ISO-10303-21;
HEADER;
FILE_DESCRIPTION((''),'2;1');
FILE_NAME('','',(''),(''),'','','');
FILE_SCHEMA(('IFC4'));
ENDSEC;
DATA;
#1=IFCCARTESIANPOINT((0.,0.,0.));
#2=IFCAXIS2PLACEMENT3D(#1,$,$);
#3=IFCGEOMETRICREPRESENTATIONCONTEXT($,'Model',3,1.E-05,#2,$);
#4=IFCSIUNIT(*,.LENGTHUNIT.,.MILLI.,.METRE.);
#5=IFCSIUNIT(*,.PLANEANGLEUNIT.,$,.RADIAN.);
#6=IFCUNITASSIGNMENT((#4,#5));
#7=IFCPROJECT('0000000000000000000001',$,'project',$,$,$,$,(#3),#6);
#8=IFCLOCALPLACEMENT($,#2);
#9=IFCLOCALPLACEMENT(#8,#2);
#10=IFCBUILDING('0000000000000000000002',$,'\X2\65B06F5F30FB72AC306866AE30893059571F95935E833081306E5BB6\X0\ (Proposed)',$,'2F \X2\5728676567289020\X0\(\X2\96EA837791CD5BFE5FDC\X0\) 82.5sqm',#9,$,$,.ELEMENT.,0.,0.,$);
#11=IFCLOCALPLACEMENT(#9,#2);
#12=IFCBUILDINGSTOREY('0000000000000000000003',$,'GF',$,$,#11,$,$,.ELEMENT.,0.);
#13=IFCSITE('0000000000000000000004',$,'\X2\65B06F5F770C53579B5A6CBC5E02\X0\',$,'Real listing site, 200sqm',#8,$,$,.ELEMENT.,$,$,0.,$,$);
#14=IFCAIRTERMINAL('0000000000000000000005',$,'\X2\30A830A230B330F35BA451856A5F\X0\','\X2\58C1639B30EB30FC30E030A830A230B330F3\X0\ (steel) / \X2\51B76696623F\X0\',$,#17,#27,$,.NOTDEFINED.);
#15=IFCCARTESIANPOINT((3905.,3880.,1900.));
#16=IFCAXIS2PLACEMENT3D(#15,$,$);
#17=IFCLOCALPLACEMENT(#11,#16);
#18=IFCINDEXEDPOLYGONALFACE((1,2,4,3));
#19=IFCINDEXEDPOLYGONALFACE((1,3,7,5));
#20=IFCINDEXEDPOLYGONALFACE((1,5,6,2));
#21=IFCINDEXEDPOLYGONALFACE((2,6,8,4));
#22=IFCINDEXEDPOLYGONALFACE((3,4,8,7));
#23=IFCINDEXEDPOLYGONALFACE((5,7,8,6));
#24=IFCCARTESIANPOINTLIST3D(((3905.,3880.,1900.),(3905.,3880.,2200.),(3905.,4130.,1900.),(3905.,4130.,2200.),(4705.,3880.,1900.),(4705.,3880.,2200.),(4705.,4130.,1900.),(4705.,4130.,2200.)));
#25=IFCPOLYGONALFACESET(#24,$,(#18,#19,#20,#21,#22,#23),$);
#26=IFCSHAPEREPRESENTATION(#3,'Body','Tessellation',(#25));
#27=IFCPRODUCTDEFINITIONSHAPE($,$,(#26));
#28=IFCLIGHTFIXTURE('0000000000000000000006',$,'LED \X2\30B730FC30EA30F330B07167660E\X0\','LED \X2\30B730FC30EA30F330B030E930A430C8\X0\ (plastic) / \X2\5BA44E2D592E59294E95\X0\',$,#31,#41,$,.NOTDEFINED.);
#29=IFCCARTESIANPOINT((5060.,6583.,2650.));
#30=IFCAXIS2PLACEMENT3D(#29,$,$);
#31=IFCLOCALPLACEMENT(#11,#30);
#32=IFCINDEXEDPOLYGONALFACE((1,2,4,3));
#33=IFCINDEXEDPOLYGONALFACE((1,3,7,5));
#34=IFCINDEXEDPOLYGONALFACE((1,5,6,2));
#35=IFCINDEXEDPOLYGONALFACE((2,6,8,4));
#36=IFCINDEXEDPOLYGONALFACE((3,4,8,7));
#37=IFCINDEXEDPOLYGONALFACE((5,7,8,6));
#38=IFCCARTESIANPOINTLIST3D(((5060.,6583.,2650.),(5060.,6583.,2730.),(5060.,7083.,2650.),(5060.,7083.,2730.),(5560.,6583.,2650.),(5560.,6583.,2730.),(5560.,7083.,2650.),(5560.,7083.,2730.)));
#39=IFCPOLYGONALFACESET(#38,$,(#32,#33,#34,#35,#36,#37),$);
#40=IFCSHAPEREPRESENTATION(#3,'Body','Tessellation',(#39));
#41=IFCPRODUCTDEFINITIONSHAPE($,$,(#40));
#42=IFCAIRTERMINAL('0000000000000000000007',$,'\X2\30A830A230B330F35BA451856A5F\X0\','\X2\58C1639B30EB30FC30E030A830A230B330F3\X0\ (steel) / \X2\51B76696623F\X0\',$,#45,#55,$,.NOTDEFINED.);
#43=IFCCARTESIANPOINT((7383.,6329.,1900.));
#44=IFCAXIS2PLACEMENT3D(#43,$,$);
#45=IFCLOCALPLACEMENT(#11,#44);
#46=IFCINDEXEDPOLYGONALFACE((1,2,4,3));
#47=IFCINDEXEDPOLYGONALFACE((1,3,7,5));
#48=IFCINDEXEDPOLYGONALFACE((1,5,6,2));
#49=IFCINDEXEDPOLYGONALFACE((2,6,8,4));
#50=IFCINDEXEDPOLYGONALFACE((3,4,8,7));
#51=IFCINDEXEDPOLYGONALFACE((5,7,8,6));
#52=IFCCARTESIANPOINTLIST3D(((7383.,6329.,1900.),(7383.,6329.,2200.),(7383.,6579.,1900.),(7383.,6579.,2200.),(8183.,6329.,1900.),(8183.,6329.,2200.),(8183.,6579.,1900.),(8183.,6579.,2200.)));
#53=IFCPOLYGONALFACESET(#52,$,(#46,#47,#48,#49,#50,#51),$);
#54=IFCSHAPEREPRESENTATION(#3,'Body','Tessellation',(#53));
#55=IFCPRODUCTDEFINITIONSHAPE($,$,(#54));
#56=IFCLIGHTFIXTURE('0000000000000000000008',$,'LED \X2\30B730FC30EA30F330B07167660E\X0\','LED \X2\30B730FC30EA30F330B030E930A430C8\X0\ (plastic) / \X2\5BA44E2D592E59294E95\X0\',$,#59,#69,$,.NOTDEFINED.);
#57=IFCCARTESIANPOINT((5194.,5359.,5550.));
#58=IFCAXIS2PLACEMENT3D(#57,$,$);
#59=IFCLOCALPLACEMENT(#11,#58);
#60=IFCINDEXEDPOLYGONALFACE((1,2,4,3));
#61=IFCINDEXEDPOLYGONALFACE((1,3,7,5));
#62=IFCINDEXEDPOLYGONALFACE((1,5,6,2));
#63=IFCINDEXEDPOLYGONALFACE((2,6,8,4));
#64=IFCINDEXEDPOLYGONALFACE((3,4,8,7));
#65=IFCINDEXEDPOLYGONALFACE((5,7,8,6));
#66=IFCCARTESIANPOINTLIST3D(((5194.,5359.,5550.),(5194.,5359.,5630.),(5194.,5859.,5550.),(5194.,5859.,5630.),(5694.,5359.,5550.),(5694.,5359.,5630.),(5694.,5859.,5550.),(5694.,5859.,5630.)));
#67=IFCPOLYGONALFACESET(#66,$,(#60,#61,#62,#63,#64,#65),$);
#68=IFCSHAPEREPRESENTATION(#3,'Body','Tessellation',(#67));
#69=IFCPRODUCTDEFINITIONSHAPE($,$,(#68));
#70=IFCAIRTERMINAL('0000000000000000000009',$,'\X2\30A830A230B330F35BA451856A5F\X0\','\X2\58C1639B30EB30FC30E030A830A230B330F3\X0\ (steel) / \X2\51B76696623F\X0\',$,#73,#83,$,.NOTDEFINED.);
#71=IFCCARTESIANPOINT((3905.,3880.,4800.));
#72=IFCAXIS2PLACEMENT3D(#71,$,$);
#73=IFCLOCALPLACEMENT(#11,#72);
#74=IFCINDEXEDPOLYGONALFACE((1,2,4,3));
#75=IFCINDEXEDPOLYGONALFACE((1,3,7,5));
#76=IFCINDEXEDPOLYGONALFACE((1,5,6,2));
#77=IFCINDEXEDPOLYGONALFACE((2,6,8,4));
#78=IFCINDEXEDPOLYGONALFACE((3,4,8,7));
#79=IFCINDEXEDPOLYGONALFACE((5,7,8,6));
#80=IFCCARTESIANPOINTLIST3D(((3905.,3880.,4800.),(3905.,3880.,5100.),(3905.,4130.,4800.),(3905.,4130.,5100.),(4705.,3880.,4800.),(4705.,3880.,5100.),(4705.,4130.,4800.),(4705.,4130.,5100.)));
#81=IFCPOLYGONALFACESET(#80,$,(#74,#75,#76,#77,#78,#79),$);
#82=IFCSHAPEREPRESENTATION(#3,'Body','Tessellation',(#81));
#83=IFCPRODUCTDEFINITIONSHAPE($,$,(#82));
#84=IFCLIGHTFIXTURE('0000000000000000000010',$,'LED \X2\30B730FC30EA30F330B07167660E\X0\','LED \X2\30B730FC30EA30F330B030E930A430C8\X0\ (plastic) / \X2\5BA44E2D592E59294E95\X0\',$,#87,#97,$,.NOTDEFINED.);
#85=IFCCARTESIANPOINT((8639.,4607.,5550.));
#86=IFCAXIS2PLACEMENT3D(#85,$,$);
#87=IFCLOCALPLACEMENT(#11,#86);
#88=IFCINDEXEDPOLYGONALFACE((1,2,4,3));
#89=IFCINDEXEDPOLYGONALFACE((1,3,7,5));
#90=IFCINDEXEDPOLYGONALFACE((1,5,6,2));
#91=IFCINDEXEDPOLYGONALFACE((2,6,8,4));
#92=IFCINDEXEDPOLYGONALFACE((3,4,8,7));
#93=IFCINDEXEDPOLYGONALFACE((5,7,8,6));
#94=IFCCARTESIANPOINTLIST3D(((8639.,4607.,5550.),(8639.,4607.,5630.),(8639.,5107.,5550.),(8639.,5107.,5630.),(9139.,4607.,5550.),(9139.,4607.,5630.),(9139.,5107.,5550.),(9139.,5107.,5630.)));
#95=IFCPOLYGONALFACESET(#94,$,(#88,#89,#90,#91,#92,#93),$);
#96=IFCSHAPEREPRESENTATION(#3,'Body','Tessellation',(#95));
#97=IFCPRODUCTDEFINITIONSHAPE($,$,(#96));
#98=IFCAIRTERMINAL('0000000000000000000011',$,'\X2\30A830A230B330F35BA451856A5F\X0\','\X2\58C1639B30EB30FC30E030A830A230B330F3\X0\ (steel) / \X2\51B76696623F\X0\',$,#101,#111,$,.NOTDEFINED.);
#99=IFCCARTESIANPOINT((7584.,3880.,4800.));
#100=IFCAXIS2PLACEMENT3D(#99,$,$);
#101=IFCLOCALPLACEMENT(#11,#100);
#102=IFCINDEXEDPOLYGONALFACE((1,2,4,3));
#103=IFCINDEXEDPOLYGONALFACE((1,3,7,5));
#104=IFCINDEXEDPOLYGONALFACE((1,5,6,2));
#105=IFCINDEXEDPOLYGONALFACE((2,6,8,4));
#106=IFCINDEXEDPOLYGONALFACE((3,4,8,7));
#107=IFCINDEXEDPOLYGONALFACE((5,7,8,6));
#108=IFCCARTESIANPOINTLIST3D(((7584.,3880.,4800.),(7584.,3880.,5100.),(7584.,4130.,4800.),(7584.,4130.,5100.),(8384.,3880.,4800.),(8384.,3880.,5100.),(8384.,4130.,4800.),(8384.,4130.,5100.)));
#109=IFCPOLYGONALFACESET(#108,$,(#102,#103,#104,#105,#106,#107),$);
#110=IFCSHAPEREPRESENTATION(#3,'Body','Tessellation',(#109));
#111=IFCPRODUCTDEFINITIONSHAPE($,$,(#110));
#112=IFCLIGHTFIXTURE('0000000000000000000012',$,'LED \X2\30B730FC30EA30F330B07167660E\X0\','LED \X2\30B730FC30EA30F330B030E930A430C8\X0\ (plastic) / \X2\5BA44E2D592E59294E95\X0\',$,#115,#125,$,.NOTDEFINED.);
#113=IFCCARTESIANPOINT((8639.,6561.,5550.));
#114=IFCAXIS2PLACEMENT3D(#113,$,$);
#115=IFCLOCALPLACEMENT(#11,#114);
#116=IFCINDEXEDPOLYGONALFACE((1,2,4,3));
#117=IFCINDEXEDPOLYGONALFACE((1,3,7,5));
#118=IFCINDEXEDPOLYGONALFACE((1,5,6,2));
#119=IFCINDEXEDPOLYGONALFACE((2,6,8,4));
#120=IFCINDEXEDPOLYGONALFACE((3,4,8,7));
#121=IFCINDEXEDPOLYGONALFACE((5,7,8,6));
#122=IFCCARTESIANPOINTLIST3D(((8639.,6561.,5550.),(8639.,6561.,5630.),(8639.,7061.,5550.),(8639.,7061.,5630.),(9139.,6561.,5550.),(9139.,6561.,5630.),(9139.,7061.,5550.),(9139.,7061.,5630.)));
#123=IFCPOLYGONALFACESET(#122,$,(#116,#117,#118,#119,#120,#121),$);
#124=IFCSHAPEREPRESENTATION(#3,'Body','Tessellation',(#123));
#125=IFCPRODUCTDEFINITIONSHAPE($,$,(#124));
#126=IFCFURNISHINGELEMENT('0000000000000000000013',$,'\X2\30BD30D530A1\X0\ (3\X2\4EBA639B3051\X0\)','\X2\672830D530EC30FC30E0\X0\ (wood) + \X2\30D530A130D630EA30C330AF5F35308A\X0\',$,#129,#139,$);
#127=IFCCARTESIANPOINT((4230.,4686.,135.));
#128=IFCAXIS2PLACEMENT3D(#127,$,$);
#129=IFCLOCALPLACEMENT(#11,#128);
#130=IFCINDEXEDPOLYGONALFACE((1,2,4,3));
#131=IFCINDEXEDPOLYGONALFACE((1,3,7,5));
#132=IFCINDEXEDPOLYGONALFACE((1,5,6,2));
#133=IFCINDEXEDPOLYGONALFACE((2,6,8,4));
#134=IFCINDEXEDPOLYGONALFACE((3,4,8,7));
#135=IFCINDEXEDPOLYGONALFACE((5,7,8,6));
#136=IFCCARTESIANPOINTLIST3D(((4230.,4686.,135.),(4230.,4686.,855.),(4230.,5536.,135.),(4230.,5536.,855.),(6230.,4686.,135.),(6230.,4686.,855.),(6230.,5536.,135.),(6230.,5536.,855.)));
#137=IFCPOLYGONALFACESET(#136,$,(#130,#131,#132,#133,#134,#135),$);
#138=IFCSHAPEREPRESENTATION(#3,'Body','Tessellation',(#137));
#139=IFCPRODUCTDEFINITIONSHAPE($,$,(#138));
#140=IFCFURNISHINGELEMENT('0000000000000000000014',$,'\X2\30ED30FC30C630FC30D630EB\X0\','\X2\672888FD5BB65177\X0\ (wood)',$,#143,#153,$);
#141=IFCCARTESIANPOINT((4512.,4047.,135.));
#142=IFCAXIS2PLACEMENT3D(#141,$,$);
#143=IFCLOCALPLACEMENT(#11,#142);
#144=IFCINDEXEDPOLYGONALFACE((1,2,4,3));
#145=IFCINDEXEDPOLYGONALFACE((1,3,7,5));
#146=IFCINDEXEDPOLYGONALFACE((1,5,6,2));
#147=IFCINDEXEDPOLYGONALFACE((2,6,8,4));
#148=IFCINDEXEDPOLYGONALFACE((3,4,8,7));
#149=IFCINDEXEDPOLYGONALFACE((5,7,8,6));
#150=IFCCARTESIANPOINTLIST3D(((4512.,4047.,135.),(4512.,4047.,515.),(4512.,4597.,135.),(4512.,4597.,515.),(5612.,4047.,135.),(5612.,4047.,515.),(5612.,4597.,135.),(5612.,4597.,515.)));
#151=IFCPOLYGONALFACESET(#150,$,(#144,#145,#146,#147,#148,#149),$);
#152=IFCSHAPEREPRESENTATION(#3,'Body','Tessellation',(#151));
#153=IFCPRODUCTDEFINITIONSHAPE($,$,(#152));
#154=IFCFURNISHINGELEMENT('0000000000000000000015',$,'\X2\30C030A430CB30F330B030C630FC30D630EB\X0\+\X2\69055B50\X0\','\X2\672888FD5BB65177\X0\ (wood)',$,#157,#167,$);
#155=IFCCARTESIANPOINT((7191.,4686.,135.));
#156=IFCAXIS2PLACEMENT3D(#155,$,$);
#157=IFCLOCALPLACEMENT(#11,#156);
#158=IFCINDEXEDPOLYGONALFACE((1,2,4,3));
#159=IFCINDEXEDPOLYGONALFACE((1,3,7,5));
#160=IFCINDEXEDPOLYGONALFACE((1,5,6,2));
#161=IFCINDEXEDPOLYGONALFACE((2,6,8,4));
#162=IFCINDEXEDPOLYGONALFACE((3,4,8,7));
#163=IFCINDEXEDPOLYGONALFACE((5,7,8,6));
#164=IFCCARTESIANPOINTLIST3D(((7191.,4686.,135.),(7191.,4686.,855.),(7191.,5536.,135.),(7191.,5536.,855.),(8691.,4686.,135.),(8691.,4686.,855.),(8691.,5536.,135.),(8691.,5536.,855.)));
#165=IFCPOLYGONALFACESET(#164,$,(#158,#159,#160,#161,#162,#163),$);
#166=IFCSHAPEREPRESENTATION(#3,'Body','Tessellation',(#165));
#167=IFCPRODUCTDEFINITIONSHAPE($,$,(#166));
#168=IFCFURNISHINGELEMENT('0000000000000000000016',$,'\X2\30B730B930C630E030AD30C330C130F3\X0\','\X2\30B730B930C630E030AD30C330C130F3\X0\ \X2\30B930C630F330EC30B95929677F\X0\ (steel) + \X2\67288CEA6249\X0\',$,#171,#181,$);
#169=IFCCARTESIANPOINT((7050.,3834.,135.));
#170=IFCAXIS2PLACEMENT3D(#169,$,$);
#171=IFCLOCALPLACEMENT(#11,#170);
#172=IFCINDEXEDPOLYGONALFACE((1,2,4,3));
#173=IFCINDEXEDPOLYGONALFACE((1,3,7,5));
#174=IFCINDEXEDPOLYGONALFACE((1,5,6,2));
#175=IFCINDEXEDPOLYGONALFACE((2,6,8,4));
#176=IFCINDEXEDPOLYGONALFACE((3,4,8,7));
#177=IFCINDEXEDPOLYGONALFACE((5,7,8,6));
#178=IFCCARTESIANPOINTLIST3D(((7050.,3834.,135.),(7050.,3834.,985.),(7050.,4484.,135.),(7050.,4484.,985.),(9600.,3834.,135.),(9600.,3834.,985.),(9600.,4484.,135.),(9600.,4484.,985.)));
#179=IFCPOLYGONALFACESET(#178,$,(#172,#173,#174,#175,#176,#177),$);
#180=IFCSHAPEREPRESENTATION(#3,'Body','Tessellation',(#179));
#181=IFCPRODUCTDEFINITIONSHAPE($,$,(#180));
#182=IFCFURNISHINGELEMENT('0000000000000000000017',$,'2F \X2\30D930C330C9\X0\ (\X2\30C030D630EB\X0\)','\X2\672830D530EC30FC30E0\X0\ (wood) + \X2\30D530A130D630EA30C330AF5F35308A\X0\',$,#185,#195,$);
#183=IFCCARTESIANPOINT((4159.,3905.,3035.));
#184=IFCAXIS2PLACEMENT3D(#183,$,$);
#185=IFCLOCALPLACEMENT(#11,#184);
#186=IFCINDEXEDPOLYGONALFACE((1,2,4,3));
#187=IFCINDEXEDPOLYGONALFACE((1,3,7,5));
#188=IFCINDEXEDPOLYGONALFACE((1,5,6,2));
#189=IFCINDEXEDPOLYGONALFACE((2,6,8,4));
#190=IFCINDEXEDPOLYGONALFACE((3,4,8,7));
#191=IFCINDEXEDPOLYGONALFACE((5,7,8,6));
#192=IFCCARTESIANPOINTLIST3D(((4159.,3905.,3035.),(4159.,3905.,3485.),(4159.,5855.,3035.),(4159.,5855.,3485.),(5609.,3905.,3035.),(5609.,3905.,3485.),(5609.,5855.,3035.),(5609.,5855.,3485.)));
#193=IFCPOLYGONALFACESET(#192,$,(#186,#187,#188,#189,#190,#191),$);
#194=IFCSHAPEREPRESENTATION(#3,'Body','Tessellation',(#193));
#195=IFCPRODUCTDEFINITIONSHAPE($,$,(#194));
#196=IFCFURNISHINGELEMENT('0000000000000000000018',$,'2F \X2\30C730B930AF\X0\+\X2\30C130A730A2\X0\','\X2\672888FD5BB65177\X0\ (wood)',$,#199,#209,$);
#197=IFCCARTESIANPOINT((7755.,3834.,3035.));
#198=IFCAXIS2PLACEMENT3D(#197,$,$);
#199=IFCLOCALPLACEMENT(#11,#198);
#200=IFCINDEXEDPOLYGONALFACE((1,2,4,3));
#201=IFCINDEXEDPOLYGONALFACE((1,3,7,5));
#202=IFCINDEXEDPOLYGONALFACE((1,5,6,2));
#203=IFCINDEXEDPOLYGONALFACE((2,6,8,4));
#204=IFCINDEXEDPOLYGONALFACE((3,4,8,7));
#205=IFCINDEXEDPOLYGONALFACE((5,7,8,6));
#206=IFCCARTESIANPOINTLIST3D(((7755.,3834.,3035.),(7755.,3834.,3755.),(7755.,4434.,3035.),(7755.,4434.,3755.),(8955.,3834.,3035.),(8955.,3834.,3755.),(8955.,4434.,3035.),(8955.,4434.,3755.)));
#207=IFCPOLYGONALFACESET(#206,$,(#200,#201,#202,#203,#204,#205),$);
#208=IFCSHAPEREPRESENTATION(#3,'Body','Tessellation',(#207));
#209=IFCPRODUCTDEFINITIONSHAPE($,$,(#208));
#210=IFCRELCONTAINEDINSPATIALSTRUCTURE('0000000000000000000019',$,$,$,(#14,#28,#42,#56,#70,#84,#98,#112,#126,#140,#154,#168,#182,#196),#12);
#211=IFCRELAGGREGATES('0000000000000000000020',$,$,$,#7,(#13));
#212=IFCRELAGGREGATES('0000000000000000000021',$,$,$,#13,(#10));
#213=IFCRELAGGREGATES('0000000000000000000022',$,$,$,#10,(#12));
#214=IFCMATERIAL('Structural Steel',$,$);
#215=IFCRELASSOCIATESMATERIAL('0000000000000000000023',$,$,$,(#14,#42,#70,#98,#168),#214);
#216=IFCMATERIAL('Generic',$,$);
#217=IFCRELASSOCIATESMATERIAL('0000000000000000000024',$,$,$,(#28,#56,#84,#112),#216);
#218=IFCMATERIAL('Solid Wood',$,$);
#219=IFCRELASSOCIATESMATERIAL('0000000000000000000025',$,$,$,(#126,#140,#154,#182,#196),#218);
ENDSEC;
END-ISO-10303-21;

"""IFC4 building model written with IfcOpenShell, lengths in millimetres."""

from ifc_helpers import new_model, si_unit, frame, frame_2d, origin, place, context, project, spatial, rectangle, extrude, material, element, save


model = new_model("IFC4")

# Units and contexts
model_context = context("Model", 3, precision=1e-05, world=origin())
ifc_project = project(units=[si_unit("LENGTHUNIT", "METRE", prefix="MILLI"), si_unit("PLANEANGLEUNIT", "RADIAN")], contexts=[model_context])

# Site, building, storey
site_placement = place(None, origin())
site = spatial("IfcSite", under=ifc_project, at=site_placement, Name="新潟県南魚沼市", ObjectType="Real listing site, 200sqm", CompositionType="ELEMENT", RefElevation=0.0)
building_placement = place(site_placement, origin())
building = spatial("IfcBuilding", under=site, at=building_placement, Name="新潟・犬と暮らす土間広めの家 (Proposed)", ObjectType="2F 在来木造(雪荷重対応) 82.5sqm", CompositionType="ELEMENT", ElevationOfRefHeight=0.0, ElevationOfTerrain=0.0)
storey_placement = place(building_placement, origin())
storey = spatial("IfcBuildingStorey", under=building, at=storey_placement, Name="GF", CompositionType="ELEMENT", Elevation=0.0)

# Shared definitions
ifc_material_1 = material(Name="Solid Wood")

# Shared definitions
ifc_material_2 = material(Name="Structural Steel")

# Shared definitions
ifc_material_3 = material(Name="Generic")

# Air terminal
air_terminal_1_placement = place(storey_placement, frame((3905.0, 3880.0, 1900.0)))
element("IfcAirTerminal", 1, at=air_terminal_1_placement, inside=storey, material=ifc_material_2, Name="エアコン室内機", Description="壁掛ルームエアコン (steel) / 冷暖房", PredefinedType="NOTDEFINED", context=model_context, shape_type="SweptSolid", body=[
    extrude(rectangle(XDim=800.0, YDim=250.0, at=frame_2d((400.0, 125.0))), frame((3905.0, 3880.0, 1900.0)), (0.0, 0.0, 1.0), 300.0),
])

# Light fixture
light_fixture_1_placement = place(storey_placement, frame((5060.0, 6583.0, 2650.0)))
element("IfcLightFixture", 2, at=light_fixture_1_placement, inside=storey, material=ifc_material_3, Name="LED シーリング照明", Description="LED シーリングライト (plastic) / 室中央天井", PredefinedType="NOTDEFINED", context=model_context, shape_type="SweptSolid", body=[
    extrude(rectangle(XDim=500.0, YDim=500.0, at=frame_2d((250.0, 250.0))), frame((5060.0, 6583.0, 2650.0)), (0.0, 0.0, 1.0), 80.0),
])

# Air terminal
air_terminal_2_placement = place(storey_placement, frame((7383.0, 6329.0, 1900.0)))
element("IfcAirTerminal", 3, at=air_terminal_2_placement, inside=storey, material=ifc_material_2, Name="エアコン室内機", Description="壁掛ルームエアコン (steel) / 冷暖房", PredefinedType="NOTDEFINED", context=model_context, shape_type="SweptSolid", body=[
    extrude(rectangle(XDim=800.0, YDim=250.0, at=frame_2d((400.0, 125.0))), frame((7383.0, 6329.0, 1900.0)), (0.0, 0.0, 1.0), 300.0),
])

# Light fixture
light_fixture_2_placement = place(storey_placement, frame((5194.0, 5359.0, 5550.0)))
element("IfcLightFixture", 4, at=light_fixture_2_placement, inside=storey, material=ifc_material_3, Name="LED シーリング照明", Description="LED シーリングライト (plastic) / 室中央天井", PredefinedType="NOTDEFINED", context=model_context, shape_type="SweptSolid", body=[
    extrude(rectangle(XDim=500.0, YDim=500.0, at=frame_2d((250.0, 250.0))), frame((5194.0, 5359.0, 5550.0)), (0.0, 0.0, 1.0), 80.0),
])

# Air terminal
air_terminal_3_placement = place(storey_placement, frame((3905.0, 3880.0, 4800.0)))
element("IfcAirTerminal", 5, at=air_terminal_3_placement, inside=storey, material=ifc_material_2, Name="エアコン室内機", Description="壁掛ルームエアコン (steel) / 冷暖房", PredefinedType="NOTDEFINED", context=model_context, shape_type="SweptSolid", body=[
    extrude(rectangle(XDim=800.0, YDim=250.0, at=frame_2d((400.0, 125.0))), frame((3905.0, 3880.0, 4800.0)), (0.0, 0.0, 1.0), 300.0),
])

# Light fixture
light_fixture_3_placement = place(storey_placement, frame((8639.0, 4607.0, 5550.0)))
element("IfcLightFixture", 6, at=light_fixture_3_placement, inside=storey, material=ifc_material_3, Name="LED シーリング照明", Description="LED シーリングライト (plastic) / 室中央天井", PredefinedType="NOTDEFINED", context=model_context, shape_type="SweptSolid", body=[
    extrude(rectangle(XDim=500.0, YDim=500.0, at=frame_2d((250.0, 250.0))), frame((8639.0, 4607.0, 5550.0)), (0.0, 0.0, 1.0), 80.0),
])

# Air terminal
air_terminal_4_placement = place(storey_placement, frame((7584.0, 3880.0, 4800.0)))
element("IfcAirTerminal", 7, at=air_terminal_4_placement, inside=storey, material=ifc_material_2, Name="エアコン室内機", Description="壁掛ルームエアコン (steel) / 冷暖房", PredefinedType="NOTDEFINED", context=model_context, shape_type="SweptSolid", body=[
    extrude(rectangle(XDim=800.0, YDim=250.0, at=frame_2d((400.0, 125.0))), frame((7584.0, 3880.0, 4800.0)), (0.0, 0.0, 1.0), 300.0),
])

# Light fixture
light_fixture_4_placement = place(storey_placement, frame((8639.0, 6561.0, 5550.0)))
element("IfcLightFixture", 8, at=light_fixture_4_placement, inside=storey, material=ifc_material_3, Name="LED シーリング照明", Description="LED シーリングライト (plastic) / 室中央天井", PredefinedType="NOTDEFINED", context=model_context, shape_type="SweptSolid", body=[
    extrude(rectangle(XDim=500.0, YDim=500.0, at=frame_2d((250.0, 250.0))), frame((8639.0, 6561.0, 5550.0)), (0.0, 0.0, 1.0), 80.0),
])

# Furnishing elements
furnishing_1_placement = place(storey_placement, frame((4230.0, 4686.0, 135.0)))
element("IfcFurnishingElement", 9, at=furnishing_1_placement, inside=storey, material=ifc_material_1, Name="ソファ (3人掛け)", Description="木フレーム (wood) + ファブリック張り", context=model_context, shape_type="SweptSolid", body=[
    extrude(rectangle(XDim=2000.0, YDim=850.0, at=frame_2d((1000.0, 425.0))), frame((4230.0, 4686.0, 135.0)), (0.0, 0.0, 1.0), 720.0),
])
furnishing_2_placement = place(storey_placement, frame((4512.0, 4047.0, 135.0)))
element("IfcFurnishingElement", 10, at=furnishing_2_placement, inside=storey, material=ifc_material_1, Name="ローテーブル", Description="木製家具 (wood)", context=model_context, shape_type="SweptSolid", body=[
    extrude(rectangle(XDim=1100.0, YDim=550.0, at=frame_2d((550.0, 275.0))), frame((4512.0, 4047.0, 135.0)), (0.0, 0.0, 1.0), 380.0),
])
furnishing_3_placement = place(storey_placement, frame((7191.0, 4686.0, 135.0)))
element("IfcFurnishingElement", 11, at=furnishing_3_placement, inside=storey, material=ifc_material_1, Name="ダイニングテーブル+椅子", Description="木製家具 (wood)", context=model_context, shape_type="SweptSolid", body=[
    extrude(rectangle(XDim=1500.0, YDim=850.0, at=frame_2d((750.0, 425.0))), frame((7191.0, 4686.0, 135.0)), (0.0, 0.0, 1.0), 720.0),
])
furnishing_4_placement = place(storey_placement, frame((7050.0, 3834.0, 135.0)))
element("IfcFurnishingElement", 12, at=furnishing_4_placement, inside=storey, material=ifc_material_2, Name="システムキッチン", Description="システムキッチン ステンレス天板 (steel) + 木質扉", context=model_context, shape_type="SweptSolid", body=[
    extrude(rectangle(XDim=2550.0, YDim=650.0, at=frame_2d((1275.0, 325.0))), frame((7050.0, 3834.0, 135.0)), (0.0, 0.0, 1.0), 850.0),
])
furnishing_5_placement = place(storey_placement, frame((4159.0, 3905.0, 3035.0)))
element("IfcFurnishingElement", 13, at=furnishing_5_placement, inside=storey, material=ifc_material_1, Name="2F ベッド (ダブル)", Description="木フレーム (wood) + ファブリック張り", context=model_context, shape_type="SweptSolid", body=[
    extrude(rectangle(XDim=1450.0, YDim=1950.0, at=frame_2d((725.0, 975.0))), frame((4159.0, 3905.0, 3035.0)), (0.0, 0.0, 1.0), 450.0),
])
furnishing_6_placement = place(storey_placement, frame((7755.0, 3834.0, 3035.0)))
element("IfcFurnishingElement", 14, at=furnishing_6_placement, inside=storey, material=ifc_material_1, Name="2F デスク+チェア", Description="木製家具 (wood)", context=model_context, shape_type="SweptSolid", body=[
    extrude(rectangle(XDim=1200.0, YDim=600.0, at=frame_2d((600.0, 300.0))), frame((7755.0, 3834.0, 3035.0)), (0.0, 0.0, 1.0), 720.0),
])

save(model, "model.ifc")
